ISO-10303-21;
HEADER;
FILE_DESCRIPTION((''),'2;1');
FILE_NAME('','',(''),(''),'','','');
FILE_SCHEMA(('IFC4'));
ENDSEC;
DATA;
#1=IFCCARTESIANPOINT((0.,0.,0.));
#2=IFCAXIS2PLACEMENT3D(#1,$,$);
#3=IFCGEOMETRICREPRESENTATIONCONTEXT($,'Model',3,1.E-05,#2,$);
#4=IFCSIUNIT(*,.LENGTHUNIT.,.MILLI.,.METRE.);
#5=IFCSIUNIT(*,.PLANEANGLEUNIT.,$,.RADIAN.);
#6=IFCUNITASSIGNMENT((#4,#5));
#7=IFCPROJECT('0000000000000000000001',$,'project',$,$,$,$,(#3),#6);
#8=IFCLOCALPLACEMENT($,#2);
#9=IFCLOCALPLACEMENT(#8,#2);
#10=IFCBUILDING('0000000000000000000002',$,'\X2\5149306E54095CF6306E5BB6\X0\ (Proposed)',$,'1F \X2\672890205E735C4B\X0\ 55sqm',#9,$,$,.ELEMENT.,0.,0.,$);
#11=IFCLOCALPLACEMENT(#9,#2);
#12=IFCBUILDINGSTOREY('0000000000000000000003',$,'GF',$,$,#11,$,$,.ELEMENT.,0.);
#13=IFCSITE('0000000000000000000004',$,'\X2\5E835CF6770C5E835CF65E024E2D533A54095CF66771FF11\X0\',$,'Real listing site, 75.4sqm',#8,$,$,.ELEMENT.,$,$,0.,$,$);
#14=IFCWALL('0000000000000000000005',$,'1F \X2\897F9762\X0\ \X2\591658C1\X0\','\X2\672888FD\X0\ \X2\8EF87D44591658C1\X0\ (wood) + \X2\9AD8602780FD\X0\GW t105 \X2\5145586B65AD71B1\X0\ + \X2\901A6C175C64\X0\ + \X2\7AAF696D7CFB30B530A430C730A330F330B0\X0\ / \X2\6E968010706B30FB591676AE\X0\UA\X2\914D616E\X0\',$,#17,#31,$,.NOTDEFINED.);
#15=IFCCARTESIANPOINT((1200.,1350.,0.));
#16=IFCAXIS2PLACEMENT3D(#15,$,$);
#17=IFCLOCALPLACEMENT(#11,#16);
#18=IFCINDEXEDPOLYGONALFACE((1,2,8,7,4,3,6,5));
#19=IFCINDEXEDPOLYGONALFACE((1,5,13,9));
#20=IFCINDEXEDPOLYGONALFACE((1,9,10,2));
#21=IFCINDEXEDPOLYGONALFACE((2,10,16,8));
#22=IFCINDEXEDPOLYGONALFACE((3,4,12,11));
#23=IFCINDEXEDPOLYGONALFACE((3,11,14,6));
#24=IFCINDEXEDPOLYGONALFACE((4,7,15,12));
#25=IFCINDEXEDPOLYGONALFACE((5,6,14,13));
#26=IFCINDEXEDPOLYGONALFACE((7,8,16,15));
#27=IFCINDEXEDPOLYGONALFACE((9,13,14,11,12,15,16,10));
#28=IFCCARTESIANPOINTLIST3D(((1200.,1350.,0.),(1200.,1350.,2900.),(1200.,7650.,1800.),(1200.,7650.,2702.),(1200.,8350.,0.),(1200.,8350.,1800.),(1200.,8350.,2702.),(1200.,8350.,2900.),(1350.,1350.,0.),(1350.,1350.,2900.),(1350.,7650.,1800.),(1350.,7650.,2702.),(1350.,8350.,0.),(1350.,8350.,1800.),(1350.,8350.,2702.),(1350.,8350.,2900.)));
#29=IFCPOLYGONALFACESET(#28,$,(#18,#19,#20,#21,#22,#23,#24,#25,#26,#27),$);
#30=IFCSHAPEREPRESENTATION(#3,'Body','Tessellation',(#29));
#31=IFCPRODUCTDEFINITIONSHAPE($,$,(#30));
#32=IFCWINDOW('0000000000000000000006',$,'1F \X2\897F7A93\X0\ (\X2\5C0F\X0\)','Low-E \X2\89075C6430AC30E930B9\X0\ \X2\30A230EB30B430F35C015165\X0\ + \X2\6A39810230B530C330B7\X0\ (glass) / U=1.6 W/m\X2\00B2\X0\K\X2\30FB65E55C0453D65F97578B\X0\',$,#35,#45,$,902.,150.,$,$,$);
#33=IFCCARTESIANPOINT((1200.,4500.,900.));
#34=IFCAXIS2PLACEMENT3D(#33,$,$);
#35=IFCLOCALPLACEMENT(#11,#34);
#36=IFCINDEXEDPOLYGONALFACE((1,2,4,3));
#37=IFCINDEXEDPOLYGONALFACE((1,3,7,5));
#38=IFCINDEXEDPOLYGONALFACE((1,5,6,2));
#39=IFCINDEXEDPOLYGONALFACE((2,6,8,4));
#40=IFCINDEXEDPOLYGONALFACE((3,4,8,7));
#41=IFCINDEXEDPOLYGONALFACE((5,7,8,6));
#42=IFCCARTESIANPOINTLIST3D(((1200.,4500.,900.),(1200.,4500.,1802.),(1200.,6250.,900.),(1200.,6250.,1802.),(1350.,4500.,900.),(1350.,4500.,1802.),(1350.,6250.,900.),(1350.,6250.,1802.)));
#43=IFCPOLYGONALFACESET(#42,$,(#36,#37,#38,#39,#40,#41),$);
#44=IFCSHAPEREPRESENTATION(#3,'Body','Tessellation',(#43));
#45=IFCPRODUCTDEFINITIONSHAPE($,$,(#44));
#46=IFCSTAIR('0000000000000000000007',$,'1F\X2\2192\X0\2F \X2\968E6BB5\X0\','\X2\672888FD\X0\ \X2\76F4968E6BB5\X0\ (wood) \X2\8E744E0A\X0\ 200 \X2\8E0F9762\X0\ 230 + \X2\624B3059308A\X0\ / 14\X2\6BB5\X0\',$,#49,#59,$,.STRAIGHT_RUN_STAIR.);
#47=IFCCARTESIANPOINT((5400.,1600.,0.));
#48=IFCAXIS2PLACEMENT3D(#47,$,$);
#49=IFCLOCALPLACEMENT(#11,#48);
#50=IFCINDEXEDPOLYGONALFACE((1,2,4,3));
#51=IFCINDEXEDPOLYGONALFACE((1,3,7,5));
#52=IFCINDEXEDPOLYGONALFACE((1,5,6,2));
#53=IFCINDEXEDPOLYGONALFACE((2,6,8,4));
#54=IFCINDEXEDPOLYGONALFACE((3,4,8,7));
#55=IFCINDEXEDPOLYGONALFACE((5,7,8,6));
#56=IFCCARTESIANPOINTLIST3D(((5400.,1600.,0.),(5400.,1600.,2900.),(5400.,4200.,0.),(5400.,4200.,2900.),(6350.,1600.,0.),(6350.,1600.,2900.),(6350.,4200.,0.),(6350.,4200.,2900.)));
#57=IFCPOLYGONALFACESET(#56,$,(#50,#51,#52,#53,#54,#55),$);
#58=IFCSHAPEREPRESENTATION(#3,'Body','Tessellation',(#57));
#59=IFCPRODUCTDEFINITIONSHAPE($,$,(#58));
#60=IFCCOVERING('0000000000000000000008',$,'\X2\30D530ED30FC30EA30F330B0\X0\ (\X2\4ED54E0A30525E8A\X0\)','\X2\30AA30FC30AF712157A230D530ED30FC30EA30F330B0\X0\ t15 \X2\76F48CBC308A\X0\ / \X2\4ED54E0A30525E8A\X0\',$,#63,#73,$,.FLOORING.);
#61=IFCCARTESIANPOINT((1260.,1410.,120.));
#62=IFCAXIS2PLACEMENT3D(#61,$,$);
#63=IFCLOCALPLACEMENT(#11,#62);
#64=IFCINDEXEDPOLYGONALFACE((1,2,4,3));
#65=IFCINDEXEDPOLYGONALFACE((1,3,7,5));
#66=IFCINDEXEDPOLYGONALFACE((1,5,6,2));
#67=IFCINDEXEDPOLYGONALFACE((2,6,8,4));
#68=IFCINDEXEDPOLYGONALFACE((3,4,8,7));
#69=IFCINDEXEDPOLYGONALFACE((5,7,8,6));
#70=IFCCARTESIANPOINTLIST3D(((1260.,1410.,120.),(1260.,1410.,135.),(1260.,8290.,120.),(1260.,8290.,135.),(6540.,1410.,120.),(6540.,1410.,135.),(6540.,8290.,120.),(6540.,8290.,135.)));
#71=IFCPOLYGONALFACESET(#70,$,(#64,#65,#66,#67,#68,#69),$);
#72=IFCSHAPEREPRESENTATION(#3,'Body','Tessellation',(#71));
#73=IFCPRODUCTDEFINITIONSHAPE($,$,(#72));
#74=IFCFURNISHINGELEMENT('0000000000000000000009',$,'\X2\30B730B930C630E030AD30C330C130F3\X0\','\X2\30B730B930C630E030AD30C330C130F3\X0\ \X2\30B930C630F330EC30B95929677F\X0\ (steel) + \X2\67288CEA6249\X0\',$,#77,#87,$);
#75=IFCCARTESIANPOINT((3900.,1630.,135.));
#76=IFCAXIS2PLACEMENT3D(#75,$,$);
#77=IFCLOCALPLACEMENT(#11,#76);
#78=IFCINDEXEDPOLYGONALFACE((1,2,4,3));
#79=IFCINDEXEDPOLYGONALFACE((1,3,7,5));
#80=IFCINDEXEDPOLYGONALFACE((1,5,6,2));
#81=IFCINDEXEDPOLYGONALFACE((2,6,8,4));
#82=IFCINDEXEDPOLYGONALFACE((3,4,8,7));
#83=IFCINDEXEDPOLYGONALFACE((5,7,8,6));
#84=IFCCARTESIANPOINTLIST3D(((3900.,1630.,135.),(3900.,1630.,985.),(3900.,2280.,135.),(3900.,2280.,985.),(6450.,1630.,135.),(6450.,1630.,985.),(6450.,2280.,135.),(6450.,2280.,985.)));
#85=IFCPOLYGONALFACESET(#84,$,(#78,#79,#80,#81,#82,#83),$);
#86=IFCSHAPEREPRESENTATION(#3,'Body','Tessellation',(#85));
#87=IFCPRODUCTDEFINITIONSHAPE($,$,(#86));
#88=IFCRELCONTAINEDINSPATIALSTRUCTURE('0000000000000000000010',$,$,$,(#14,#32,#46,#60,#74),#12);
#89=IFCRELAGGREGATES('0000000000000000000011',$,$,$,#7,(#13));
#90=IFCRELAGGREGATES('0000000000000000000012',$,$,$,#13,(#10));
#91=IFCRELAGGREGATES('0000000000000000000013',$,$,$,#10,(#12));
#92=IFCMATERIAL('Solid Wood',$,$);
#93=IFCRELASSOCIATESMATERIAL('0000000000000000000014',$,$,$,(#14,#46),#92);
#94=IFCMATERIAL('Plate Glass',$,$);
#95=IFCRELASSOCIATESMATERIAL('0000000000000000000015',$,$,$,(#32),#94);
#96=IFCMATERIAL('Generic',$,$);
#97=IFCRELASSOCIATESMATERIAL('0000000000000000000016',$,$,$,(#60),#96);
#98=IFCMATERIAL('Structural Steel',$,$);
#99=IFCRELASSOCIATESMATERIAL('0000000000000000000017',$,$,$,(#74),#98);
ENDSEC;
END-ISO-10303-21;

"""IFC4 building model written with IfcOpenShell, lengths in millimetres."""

from ifc_helpers import new_model, si_unit, frame, frame_2d, origin, place, context, project, spatial, rectangle, extrude, material, element, fill, save


model = new_model("IFC4")

# Units and contexts
model_context = context("Model", 3, precision=1e-05, world=origin())
ifc_project = project(units=[si_unit("LENGTHUNIT", "METRE", prefix="MILLI"), si_unit("PLANEANGLEUNIT", "RADIAN")], contexts=[model_context])

# Site, building, storey
site_placement = place(None, origin())
site = spatial("IfcSite", under=ifc_project, at=site_placement, Name="広島県広島市中区吉島東１", ObjectType="Real listing site, 75.4sqm", CompositionType="ELEMENT", RefElevation=0.0)
building_placement = place(site_placement, origin())
building = spatial("IfcBuilding", under=site, at=building_placement, Name="光の吉島の家 (Proposed)", ObjectType="1F 木造平屋 55sqm", CompositionType="ELEMENT", ElevationOfRefHeight=0.0, ElevationOfTerrain=0.0)
storey_placement = place(building_placement, origin())
storey = spatial("IfcBuildingStorey", under=building, at=storey_placement, Name="GF", CompositionType="ELEMENT", Elevation=0.0)

# Shared definitions
ifc_material_1 = material(Name="Solid Wood")
ifc_material_2 = material(Name="Generic")

# Shared definitions
ifc_material_3 = material(Name="Plate Glass")

# Wall, opening, window
wall_1_placement = place(storey_placement, frame((1200.0, 1350.0, 0.0)))
wall_1 = element("IfcWall", 1, at=wall_1_placement, inside=storey, material=ifc_material_1, Name="1F 西面 外壁", Description="木製 軸組外壁 (wood) + 高性能GW t105 充填断熱 + 通気層 + 窯業系サイディング / 準耐火・外皮UA配慮", PredefinedType="NOTDEFINED", context=model_context, shape_type="SweptSolid", body=[
    extrude(rectangle(XDim=150.0, YDim=7000.0, at=frame_2d((75.0, 3500.0))), frame((1200.0, 1350.0, 0.0)), (0.0, 0.0, 1.0), 2900.0),
])
opening_1_placement = place(storey_placement, frame((1200.0, 4500.0, 900.0)))
opening_1 = element("IfcOpeningElement", 2, at=opening_1_placement, cuts=wall_1, PredefinedType="NOTDEFINED", context=model_context, shape_type="SweptSolid", body=[
    extrude(rectangle(XDim=150.0, YDim=1750.0, at=frame_2d((75.0, 875.0))), frame((1200.0, 4500.0, 900.0)), (0.0, 0.0, 1.0), 902.0),
])
window_1_placement = place(storey_placement, frame((1200.0, 4500.0, 900.0)))
window_1 = element("IfcWindow", 3, at=window_1_placement, inside=storey, material=ifc_material_3, Name="1F 西窓 (小)", Description="Low-E 複層ガラス アルゴン封入 + 樹脂サッシ (glass) / U=1.6 W/m²K・日射取得型", OverallHeight=902.0, OverallWidth=150.0, context=model_context, shape_type="SweptSolid", body=[
    extrude(rectangle(XDim=150.0, YDim=1750.0, at=frame_2d((75.0, 875.0))), frame((1200.0, 4500.0, 900.0)), (0.0, 0.0, 1.0), 902.0),
])
fill(opening_1, window_1)

# Stair
stair_placement = place(storey_placement, frame((5400.0, 1600.0, 0.0)))
element("IfcStair", 4, at=stair_placement, inside=storey, material=ifc_material_1, Name="1F→2F 階段", Description="木製 直階段 (wood) 蹴上 200 踏面 230 + 手すり / 14段", PredefinedType="STRAIGHT_RUN_STAIR", context=model_context, shape_type="SweptSolid", body=[
    extrude(rectangle(XDim=950.0, YDim=2600.0, at=frame_2d((475.0, 1300.0))), frame((5400.0, 1600.0, 0.0)), (0.0, 0.0, 1.0), 2900.0),
])

# Covering
covering_placement = place(storey_placement, frame((1260.0, 1410.0, 120.0)))
element("IfcCovering", 5, at=covering_placement, inside=storey, material=ifc_material_2, Name="フローリング (仕上げ床)", Description="オーク無垢フローリング t15 直貼り / 仕上げ床", PredefinedType="FLOORING", context=model_context, shape_type="SweptSolid", body=[
    extrude(rectangle(XDim=5280.0, YDim=6880.0, at=frame_2d((2640.0, 3440.0))), frame((1260.0, 1410.0, 120.0)), (0.0, 0.0, 1.0), 15.0),
])

# Furnishing element
ifc_material_4 = material(Name="Structural Steel")
furnishing_placement = place(storey_placement, frame((3900.0, 1630.0, 135.0)))
element("IfcFurnishingElement", 6, at=furnishing_placement, inside=storey, material=ifc_material_4, Name="システムキッチン", Description="システムキッチン ステンレス天板 (steel) + 木質扉", context=model_context, shape_type="SweptSolid", body=[
    extrude(rectangle(XDim=2550.0, YDim=650.0, at=frame_2d((1275.0, 325.0))), frame((3900.0, 1630.0, 135.0)), (0.0, 0.0, 1.0), 850.0),
])

save(model, "model.ifc")
